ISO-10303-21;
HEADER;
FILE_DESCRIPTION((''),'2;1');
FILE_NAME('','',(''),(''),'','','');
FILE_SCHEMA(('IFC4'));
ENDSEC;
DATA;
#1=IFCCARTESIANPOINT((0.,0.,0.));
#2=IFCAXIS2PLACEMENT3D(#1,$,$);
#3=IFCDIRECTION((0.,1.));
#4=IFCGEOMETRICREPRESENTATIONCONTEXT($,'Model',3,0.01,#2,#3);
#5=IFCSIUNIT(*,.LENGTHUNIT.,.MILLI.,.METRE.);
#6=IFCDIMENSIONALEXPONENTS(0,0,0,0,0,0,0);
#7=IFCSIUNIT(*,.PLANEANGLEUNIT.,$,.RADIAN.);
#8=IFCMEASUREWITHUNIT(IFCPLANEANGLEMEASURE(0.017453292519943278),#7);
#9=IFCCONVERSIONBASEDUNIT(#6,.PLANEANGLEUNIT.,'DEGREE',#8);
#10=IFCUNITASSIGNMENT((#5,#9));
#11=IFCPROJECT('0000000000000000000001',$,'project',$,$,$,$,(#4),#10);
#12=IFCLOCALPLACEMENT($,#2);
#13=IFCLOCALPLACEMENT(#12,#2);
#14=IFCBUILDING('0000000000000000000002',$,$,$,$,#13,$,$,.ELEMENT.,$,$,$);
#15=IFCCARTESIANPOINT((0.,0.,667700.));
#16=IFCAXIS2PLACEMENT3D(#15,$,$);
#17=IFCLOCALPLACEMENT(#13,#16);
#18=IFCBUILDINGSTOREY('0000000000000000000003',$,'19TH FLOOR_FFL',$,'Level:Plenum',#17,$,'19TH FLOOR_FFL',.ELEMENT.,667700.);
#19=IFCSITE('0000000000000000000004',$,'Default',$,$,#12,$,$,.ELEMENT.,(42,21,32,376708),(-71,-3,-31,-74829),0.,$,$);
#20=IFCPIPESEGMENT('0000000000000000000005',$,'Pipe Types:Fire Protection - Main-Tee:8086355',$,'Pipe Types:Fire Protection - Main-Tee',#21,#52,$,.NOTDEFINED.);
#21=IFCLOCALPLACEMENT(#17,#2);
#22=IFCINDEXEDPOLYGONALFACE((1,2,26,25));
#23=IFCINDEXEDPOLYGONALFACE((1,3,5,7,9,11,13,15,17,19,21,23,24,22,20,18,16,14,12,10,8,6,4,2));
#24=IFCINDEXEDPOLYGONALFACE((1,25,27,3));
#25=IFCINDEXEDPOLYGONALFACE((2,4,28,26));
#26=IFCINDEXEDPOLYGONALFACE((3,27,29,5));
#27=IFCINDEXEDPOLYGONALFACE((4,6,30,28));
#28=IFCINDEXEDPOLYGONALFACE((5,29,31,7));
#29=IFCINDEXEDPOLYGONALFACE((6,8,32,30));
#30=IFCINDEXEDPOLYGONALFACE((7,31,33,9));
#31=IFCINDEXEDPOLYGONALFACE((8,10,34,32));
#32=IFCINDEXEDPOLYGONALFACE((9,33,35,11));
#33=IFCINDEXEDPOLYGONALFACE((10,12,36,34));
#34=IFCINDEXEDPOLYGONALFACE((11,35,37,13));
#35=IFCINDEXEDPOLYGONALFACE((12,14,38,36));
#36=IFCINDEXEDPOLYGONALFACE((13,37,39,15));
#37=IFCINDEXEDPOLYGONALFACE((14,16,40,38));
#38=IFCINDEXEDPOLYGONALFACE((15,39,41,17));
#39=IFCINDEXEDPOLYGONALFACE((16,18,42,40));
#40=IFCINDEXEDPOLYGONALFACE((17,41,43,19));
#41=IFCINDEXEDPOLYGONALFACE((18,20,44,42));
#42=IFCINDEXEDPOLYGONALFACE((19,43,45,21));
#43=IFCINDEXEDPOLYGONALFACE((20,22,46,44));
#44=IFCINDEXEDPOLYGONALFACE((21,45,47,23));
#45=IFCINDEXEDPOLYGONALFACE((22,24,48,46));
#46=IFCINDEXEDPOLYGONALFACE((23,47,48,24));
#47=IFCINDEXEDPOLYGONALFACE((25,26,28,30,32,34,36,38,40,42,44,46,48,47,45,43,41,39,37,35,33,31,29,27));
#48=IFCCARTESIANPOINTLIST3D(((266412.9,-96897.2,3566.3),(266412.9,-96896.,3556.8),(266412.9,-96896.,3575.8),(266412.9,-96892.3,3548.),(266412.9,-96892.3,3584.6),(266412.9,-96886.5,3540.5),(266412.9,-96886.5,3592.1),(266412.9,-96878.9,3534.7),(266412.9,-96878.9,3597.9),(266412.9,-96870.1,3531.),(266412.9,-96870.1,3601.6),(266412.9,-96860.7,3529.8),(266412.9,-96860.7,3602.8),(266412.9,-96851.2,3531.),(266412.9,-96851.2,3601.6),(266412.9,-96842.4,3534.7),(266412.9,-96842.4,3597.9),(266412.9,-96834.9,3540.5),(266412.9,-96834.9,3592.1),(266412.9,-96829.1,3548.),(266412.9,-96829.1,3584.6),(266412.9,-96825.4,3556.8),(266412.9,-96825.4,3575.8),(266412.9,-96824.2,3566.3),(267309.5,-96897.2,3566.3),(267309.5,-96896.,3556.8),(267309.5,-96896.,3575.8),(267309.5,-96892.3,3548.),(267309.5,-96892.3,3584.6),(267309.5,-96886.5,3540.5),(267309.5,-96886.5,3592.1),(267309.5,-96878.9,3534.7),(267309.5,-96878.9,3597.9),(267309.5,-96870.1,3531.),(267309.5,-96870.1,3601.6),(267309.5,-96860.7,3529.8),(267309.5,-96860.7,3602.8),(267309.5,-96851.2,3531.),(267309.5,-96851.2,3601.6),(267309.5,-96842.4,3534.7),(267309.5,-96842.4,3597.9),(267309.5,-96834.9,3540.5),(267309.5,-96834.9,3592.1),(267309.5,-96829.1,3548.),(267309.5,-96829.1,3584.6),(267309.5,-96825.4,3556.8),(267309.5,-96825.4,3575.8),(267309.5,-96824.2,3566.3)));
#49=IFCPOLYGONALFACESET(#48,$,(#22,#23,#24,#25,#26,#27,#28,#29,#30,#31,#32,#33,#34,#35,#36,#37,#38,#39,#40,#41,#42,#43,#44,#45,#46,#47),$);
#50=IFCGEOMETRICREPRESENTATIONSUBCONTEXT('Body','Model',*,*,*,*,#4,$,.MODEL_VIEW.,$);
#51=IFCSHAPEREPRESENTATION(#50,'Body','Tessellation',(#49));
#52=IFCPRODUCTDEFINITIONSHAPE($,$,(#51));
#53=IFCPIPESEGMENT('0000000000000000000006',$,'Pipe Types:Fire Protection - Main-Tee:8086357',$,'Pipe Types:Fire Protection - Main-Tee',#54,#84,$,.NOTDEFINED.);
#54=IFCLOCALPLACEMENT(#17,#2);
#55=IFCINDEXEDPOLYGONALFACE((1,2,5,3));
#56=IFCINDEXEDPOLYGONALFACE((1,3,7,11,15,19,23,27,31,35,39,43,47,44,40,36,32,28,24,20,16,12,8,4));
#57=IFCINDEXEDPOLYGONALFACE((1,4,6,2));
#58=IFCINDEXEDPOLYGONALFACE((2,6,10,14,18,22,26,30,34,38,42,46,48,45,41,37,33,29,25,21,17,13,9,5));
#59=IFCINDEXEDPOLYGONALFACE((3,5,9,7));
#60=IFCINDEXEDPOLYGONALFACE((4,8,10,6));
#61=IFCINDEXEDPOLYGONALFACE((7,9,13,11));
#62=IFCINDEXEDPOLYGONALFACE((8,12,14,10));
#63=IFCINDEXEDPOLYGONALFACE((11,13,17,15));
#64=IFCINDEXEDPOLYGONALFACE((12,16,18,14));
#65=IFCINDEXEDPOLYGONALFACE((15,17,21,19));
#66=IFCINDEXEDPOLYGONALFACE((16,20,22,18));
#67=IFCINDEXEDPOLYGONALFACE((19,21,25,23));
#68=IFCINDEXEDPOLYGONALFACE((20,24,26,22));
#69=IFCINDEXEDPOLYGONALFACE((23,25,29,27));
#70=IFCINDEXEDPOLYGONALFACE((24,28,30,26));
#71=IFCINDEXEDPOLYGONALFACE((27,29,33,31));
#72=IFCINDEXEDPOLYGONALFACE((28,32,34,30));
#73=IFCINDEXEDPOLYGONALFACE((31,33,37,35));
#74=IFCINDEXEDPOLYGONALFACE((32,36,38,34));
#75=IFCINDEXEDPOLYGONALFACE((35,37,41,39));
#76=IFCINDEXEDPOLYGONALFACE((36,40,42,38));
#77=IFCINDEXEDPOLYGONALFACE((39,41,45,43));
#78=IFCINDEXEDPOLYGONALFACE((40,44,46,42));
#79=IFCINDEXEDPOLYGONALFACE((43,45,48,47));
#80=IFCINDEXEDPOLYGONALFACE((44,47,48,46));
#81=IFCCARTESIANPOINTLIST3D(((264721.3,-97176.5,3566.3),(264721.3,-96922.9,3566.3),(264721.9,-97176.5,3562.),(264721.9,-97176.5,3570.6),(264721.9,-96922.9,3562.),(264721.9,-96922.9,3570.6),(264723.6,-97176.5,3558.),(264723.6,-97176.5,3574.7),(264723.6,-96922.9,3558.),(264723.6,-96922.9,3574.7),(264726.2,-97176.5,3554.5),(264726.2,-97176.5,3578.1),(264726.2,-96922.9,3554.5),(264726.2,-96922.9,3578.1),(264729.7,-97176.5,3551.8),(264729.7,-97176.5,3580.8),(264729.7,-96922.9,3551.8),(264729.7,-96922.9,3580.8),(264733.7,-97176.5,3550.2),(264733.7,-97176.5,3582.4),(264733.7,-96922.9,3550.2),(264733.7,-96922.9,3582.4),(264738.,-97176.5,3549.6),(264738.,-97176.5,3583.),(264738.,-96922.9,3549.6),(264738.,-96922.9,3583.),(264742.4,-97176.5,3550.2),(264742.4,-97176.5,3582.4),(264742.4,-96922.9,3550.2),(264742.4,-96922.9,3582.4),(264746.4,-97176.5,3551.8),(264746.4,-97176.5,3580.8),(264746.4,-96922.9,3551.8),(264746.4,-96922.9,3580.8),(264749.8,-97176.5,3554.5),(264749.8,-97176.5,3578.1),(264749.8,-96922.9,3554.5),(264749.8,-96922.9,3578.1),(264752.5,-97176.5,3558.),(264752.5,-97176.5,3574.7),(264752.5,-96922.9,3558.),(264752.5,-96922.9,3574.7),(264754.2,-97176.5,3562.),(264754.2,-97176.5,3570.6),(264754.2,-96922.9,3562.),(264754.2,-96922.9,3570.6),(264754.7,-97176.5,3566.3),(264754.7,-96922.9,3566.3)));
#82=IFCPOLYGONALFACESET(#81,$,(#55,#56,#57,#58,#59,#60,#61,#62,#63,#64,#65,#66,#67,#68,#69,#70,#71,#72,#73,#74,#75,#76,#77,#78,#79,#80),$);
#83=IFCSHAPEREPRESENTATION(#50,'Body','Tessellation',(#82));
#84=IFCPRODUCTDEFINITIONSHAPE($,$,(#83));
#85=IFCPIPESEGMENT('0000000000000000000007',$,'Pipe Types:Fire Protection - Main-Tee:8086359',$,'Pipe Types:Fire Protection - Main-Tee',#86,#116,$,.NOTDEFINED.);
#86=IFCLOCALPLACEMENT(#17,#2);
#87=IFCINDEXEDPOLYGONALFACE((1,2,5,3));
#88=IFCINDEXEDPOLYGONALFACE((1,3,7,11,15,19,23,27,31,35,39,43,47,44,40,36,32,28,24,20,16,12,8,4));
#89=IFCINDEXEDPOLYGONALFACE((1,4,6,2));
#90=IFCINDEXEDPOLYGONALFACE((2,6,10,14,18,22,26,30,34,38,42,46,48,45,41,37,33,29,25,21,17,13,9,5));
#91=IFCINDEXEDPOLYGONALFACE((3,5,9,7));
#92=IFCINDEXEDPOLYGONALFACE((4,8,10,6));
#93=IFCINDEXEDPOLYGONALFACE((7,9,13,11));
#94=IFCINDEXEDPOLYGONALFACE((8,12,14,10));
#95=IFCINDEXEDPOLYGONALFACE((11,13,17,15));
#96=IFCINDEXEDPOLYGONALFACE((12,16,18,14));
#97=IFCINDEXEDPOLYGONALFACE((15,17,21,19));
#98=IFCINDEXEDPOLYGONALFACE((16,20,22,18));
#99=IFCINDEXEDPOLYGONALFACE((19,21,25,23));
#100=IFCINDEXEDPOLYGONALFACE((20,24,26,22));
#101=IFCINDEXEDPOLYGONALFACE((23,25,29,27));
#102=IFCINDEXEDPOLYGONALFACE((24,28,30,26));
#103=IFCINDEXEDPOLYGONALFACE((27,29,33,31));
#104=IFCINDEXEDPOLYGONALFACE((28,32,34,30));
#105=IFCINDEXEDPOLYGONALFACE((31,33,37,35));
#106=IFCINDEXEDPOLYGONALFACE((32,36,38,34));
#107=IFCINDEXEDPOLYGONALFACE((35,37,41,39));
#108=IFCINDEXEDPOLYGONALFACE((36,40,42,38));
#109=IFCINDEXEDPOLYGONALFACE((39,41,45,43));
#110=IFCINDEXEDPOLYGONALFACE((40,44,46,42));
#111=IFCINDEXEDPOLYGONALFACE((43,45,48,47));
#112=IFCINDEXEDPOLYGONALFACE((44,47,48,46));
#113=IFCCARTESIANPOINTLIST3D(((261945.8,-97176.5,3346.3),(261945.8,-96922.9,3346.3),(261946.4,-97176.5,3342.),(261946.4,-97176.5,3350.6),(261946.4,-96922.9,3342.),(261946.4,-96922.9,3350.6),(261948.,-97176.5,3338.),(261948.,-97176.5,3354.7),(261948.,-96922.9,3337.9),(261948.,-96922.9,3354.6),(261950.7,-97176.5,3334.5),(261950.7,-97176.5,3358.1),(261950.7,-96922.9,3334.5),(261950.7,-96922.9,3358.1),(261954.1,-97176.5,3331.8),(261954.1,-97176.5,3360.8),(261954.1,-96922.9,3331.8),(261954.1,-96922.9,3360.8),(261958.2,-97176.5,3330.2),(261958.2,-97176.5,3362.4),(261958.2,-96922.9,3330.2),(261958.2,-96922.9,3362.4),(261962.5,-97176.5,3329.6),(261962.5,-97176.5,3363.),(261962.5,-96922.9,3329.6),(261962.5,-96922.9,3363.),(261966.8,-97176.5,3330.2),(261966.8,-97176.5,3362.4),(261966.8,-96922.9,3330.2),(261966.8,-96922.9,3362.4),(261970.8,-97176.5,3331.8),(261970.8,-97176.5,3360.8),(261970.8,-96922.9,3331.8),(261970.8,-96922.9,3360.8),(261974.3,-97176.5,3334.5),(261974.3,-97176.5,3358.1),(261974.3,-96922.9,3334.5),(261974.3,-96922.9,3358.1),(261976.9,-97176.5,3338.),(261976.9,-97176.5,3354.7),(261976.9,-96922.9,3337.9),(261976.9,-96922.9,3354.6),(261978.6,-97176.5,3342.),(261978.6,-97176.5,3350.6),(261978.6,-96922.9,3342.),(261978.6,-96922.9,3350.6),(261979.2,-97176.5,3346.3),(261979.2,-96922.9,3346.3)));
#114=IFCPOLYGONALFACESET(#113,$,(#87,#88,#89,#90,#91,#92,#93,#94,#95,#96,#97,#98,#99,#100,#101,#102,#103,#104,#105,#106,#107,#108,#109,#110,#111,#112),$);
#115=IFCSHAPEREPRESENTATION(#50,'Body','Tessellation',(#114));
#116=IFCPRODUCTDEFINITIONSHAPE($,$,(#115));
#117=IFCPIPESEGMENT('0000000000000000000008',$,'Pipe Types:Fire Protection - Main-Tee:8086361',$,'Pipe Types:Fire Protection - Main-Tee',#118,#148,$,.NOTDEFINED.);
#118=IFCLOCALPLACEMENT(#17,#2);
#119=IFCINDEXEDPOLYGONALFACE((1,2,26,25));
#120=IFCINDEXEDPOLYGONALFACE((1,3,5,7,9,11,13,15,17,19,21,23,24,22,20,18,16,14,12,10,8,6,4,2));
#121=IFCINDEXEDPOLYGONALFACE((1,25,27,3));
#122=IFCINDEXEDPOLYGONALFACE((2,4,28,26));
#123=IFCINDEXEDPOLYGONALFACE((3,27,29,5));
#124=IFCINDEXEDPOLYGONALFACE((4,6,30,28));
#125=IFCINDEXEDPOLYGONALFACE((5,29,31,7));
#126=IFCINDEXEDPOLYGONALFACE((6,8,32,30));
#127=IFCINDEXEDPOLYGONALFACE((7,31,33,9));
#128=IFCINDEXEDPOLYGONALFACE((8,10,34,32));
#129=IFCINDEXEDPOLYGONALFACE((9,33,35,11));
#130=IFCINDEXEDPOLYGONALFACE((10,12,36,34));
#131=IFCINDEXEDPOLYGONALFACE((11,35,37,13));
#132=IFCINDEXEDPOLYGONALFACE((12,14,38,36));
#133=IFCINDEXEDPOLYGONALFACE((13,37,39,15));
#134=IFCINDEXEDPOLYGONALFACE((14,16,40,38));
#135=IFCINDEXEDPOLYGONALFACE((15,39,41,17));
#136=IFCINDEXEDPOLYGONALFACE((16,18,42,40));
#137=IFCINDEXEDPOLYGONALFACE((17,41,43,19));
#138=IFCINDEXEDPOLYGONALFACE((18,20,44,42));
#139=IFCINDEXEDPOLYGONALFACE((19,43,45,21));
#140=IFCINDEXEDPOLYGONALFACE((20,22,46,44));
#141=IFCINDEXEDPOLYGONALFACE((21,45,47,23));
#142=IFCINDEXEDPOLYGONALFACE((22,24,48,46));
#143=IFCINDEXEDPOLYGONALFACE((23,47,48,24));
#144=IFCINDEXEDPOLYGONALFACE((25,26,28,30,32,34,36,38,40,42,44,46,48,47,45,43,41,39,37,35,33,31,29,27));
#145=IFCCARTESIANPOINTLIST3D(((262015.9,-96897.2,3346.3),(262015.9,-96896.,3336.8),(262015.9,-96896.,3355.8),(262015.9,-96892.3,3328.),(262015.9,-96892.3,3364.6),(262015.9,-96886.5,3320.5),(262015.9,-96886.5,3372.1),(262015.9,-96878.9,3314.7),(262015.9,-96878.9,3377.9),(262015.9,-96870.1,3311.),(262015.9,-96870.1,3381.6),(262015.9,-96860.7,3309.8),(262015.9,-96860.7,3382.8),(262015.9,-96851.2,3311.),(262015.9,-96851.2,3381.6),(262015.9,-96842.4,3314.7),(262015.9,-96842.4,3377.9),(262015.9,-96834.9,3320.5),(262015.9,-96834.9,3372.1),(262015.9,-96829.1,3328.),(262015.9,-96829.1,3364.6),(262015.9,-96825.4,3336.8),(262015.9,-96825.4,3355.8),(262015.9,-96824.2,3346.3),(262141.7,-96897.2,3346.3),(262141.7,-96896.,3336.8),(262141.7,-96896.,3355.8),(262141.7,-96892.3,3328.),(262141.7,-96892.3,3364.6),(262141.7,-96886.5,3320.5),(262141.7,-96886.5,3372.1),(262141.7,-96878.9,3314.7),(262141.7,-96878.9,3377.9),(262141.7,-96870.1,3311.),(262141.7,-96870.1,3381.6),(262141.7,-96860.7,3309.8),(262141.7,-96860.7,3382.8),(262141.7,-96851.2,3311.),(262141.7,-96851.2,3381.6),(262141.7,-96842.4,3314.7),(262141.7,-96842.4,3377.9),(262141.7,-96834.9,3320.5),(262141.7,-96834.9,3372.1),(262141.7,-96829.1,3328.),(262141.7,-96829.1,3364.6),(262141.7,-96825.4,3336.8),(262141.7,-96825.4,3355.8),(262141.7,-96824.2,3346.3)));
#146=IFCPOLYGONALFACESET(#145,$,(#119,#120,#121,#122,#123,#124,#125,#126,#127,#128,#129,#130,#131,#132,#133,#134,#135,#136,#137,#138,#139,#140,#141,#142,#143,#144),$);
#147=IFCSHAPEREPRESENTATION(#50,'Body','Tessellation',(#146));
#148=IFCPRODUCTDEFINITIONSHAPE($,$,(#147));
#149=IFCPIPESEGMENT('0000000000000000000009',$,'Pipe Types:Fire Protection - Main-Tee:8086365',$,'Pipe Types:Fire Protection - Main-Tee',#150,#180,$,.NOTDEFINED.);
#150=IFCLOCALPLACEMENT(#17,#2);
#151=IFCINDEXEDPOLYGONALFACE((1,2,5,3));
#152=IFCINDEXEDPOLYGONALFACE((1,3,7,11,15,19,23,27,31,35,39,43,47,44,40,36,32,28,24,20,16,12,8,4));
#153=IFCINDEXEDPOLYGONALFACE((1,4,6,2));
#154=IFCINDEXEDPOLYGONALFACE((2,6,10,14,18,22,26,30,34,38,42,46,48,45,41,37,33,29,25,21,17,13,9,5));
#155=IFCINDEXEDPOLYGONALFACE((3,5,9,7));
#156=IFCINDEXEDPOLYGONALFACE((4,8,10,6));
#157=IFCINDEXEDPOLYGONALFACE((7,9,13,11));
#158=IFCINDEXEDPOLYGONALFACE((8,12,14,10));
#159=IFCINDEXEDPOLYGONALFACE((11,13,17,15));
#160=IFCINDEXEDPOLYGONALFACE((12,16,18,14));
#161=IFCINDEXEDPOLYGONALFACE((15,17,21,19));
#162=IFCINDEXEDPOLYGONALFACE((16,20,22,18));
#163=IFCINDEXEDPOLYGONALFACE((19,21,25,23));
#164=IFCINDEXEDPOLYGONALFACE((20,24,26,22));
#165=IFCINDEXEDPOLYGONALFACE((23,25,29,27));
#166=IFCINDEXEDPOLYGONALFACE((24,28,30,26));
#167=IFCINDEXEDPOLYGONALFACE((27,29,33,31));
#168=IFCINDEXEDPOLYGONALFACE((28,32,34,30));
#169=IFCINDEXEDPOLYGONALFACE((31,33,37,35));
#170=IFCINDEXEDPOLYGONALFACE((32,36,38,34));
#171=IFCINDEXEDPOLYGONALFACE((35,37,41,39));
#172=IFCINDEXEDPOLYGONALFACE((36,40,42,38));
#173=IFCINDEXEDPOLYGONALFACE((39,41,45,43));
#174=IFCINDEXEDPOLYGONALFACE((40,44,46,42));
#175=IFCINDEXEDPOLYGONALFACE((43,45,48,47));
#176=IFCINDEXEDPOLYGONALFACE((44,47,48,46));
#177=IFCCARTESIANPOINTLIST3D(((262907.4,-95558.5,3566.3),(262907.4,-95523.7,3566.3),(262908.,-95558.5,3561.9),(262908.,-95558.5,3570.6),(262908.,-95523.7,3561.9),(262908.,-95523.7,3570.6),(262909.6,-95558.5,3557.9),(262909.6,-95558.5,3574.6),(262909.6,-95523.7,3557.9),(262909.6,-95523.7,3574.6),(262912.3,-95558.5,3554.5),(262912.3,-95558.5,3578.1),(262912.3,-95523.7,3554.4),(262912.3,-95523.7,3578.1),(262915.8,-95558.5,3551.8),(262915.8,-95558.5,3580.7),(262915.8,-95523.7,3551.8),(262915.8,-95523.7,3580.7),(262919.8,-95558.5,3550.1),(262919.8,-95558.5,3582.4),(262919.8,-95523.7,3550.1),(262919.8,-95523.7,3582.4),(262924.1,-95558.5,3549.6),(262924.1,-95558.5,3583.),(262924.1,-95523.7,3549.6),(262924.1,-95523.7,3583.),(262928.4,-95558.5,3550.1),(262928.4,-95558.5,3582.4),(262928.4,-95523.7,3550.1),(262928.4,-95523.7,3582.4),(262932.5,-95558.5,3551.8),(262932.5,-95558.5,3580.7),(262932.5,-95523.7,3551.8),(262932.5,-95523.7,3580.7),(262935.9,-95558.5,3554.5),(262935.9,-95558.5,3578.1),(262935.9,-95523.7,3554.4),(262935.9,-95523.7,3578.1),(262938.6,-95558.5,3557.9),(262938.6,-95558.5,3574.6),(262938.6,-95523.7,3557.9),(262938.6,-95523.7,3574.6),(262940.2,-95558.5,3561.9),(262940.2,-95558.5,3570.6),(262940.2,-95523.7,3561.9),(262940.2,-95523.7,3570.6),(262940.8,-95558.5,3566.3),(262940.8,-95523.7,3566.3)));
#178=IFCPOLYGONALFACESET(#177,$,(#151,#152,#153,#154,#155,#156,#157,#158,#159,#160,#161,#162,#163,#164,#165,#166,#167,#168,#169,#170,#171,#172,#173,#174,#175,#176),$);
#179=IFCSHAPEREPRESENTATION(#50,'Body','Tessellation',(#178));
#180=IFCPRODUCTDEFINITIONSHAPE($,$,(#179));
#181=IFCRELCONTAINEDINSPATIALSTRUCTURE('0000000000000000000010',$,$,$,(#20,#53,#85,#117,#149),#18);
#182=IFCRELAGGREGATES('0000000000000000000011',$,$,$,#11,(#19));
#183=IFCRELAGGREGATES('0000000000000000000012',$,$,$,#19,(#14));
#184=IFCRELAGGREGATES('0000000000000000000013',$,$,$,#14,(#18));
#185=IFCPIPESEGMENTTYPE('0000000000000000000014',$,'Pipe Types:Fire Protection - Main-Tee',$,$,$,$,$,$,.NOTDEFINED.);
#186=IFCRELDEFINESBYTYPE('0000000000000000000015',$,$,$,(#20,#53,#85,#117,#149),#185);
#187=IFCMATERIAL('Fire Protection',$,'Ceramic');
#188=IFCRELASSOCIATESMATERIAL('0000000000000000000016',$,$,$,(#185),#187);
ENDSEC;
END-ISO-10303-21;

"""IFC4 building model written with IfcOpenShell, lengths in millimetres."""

from ifc_helpers import new_model, entity, si_unit, converted_unit, direction, frame, origin, place, context, subcontext, project, spatial, arc, indexed_curve, outline, extrude, material, type_object, element, save


model = new_model("IFC4")

# Units and contexts
model_context = context("Model", 3, precision=0.01, world=origin(), true_north=direction((0.0, 1.0)))
body_context = subcontext(model_context, "Body", "Model", "MODEL_VIEW")
ifc_project = project(units=[si_unit("LENGTHUNIT", "METRE", prefix="MILLI"), converted_unit("PLANEANGLEUNIT", "DEGREE", entity("IfcPlaneAngleMeasure", 0.017453292519943278), si_unit("PLANEANGLEUNIT", "RADIAN"), dimensions=[0, 0, 0, 0, 0, 0, 0])], contexts=[model_context])

# Site, building, storey
site_placement = place(None, origin())
site = spatial("IfcSite", under=ifc_project, at=site_placement, Name="Default", CompositionType="ELEMENT", RefLatitude=(42, 21, 32, 376708), RefLongitude=(-71, -3, -31, -74829), RefElevation=0.0)
building_placement = place(site_placement, origin())
building = spatial("IfcBuilding", under=site, at=building_placement, CompositionType="ELEMENT")
storey_placement = place(building_placement, frame((0.0, 0.0, 667700.0)))
storey = spatial("IfcBuildingStorey", under=building, at=storey_placement, Name="19TH FLOOR_FFL", ObjectType="Level:Plenum", LongName="19TH FLOOR_FFL", CompositionType="ELEMENT", Elevation=667700.0)

# Pipe segments
ifc_material_1 = material(Name="Fire Protection", Category="Ceramic")
pipe_segment_type = type_object("IfcPipeSegmentType", Name="Pipe Types:Fire Protection - Main-Tee", PredefinedType="NOTDEFINED", material=ifc_material_1)
pipe_segment_1_placement = place(storey_placement, origin())
element("IfcPipeSegment", 1, at=pipe_segment_1_placement, inside=storey, type_object=pipe_segment_type, Name="Pipe Types:Fire Protection - Main-Tee:8086355", ObjectType="Pipe Types:Fire Protection - Main-Tee", PredefinedType="NOTDEFINED", context=body_context, shape_type="SweptSolid", body=[
    extrude(outline(indexed_curve([(36.5, 0.0), (25.8, 25.8), (0.0, 36.5), (-25.8, 25.8), (-36.5, 0.0), (-25.8, -25.8), (0.0, -36.5), (25.8, -25.8)], segments=[arc(1, 2, 3), arc(3, 4, 5), arc(5, 6, 7), arc(7, 8, 1)], self_intersect=False)), frame((266412.9, -96860.7, 3566.3), z_axis=(1.0, 0.0, 0.0), x_axis=(0.0, 1.0, 0.0)), (0.0, 0.0, 1.0), 896.6),
])
pipe_segment_2_placement = place(storey_placement, origin())
element("IfcPipeSegment", 2, at=pipe_segment_2_placement, inside=storey, type_object=pipe_segment_type, Name="Pipe Types:Fire Protection - Main-Tee:8086357", ObjectType="Pipe Types:Fire Protection - Main-Tee", PredefinedType="NOTDEFINED", context=body_context, shape_type="SweptSolid", body=[
    extrude(outline(indexed_curve([(16.7, 0.0), (11.8, 11.8), (0.0, 16.7), (-11.8, 11.8), (-16.7, 0.0), (-11.8, -11.8), (0.0, -16.7), (11.8, -11.8)], segments=[arc(1, 2, 3), arc(3, 4, 5), arc(5, 6, 7), arc(7, 8, 1)], self_intersect=False)), frame((264738.0, -97176.5, 3566.3), z_axis=(0.0, 1.0, 0.0), x_axis=(-1.0, 0.0, 0.0)), (0.0, 0.0, 1.0), 253.5),
])
pipe_segment_3_placement = place(storey_placement, origin())
element("IfcPipeSegment", 3, at=pipe_segment_3_placement, inside=storey, type_object=pipe_segment_type, Name="Pipe Types:Fire Protection - Main-Tee:8086359", ObjectType="Pipe Types:Fire Protection - Main-Tee", PredefinedType="NOTDEFINED", context=body_context, shape_type="SweptSolid", body=[
    extrude(outline(indexed_curve([(16.7, 0.0), (11.8, 11.8), (0.0, 16.7), (-11.8, 11.8), (-16.7, 0.0), (-11.8, -11.8), (0.0, -16.7), (11.8, -11.8)], segments=[arc(1, 2, 3), arc(3, 4, 5), arc(5, 6, 7), arc(7, 8, 1)], self_intersect=False)), frame((261962.5, -96922.9, 3346.3), z_axis=(0.0, -1.0, 0.000014), x_axis=(-1.0, 0.0, 0.0)), (0.0, 0.0, 1.0), 253.5),
])
pipe_segment_4_placement = place(storey_placement, origin())
element("IfcPipeSegment", 4, at=pipe_segment_4_placement, inside=storey, type_object=pipe_segment_type, Name="Pipe Types:Fire Protection - Main-Tee:8086361", ObjectType="Pipe Types:Fire Protection - Main-Tee", PredefinedType="NOTDEFINED", context=body_context, shape_type="SweptSolid", body=[
    extrude(outline(indexed_curve([(36.5, 0.0), (25.8, 25.8), (0.0, 36.5), (-25.8, 25.8), (-36.5, 0.0), (-25.8, -25.8), (0.0, -36.5), (25.8, -25.8)], segments=[arc(1, 2, 3), arc(3, 4, 5), arc(5, 6, 7), arc(7, 8, 1)], self_intersect=False)), frame((262015.9, -96860.7, 3346.3), z_axis=(1.0, 0.0, 0.0), x_axis=(0.0, -1.0, 0.0)), (0.0, 0.0, 1.0), 125.8),
])
pipe_segment_5_placement = place(storey_placement, origin())
element("IfcPipeSegment", 5, at=pipe_segment_5_placement, inside=storey, type_object=pipe_segment_type, Name="Pipe Types:Fire Protection - Main-Tee:8086365", ObjectType="Pipe Types:Fire Protection - Main-Tee", PredefinedType="NOTDEFINED", context=body_context, shape_type="SweptSolid", body=[
    extrude(outline(indexed_curve([(16.7, 0.0), (11.8, 11.8), (0.0, 16.7), (-11.8, 11.8), (-16.7, 0.0), (-11.8, -11.8), (0.0, -16.7), (11.8, -11.8)], segments=[arc(1, 2, 3), arc(3, 4, 5), arc(5, 6, 7), arc(7, 8, 1)], self_intersect=False)), frame((262924.1, -95523.7, 3566.3), z_axis=(0.0, -1.0, 0.000344), x_axis=(1.0, 0.0, 0.0)), (0.0, 0.0, 1.0), 34.8),
])

save(model, "model.ifc")
